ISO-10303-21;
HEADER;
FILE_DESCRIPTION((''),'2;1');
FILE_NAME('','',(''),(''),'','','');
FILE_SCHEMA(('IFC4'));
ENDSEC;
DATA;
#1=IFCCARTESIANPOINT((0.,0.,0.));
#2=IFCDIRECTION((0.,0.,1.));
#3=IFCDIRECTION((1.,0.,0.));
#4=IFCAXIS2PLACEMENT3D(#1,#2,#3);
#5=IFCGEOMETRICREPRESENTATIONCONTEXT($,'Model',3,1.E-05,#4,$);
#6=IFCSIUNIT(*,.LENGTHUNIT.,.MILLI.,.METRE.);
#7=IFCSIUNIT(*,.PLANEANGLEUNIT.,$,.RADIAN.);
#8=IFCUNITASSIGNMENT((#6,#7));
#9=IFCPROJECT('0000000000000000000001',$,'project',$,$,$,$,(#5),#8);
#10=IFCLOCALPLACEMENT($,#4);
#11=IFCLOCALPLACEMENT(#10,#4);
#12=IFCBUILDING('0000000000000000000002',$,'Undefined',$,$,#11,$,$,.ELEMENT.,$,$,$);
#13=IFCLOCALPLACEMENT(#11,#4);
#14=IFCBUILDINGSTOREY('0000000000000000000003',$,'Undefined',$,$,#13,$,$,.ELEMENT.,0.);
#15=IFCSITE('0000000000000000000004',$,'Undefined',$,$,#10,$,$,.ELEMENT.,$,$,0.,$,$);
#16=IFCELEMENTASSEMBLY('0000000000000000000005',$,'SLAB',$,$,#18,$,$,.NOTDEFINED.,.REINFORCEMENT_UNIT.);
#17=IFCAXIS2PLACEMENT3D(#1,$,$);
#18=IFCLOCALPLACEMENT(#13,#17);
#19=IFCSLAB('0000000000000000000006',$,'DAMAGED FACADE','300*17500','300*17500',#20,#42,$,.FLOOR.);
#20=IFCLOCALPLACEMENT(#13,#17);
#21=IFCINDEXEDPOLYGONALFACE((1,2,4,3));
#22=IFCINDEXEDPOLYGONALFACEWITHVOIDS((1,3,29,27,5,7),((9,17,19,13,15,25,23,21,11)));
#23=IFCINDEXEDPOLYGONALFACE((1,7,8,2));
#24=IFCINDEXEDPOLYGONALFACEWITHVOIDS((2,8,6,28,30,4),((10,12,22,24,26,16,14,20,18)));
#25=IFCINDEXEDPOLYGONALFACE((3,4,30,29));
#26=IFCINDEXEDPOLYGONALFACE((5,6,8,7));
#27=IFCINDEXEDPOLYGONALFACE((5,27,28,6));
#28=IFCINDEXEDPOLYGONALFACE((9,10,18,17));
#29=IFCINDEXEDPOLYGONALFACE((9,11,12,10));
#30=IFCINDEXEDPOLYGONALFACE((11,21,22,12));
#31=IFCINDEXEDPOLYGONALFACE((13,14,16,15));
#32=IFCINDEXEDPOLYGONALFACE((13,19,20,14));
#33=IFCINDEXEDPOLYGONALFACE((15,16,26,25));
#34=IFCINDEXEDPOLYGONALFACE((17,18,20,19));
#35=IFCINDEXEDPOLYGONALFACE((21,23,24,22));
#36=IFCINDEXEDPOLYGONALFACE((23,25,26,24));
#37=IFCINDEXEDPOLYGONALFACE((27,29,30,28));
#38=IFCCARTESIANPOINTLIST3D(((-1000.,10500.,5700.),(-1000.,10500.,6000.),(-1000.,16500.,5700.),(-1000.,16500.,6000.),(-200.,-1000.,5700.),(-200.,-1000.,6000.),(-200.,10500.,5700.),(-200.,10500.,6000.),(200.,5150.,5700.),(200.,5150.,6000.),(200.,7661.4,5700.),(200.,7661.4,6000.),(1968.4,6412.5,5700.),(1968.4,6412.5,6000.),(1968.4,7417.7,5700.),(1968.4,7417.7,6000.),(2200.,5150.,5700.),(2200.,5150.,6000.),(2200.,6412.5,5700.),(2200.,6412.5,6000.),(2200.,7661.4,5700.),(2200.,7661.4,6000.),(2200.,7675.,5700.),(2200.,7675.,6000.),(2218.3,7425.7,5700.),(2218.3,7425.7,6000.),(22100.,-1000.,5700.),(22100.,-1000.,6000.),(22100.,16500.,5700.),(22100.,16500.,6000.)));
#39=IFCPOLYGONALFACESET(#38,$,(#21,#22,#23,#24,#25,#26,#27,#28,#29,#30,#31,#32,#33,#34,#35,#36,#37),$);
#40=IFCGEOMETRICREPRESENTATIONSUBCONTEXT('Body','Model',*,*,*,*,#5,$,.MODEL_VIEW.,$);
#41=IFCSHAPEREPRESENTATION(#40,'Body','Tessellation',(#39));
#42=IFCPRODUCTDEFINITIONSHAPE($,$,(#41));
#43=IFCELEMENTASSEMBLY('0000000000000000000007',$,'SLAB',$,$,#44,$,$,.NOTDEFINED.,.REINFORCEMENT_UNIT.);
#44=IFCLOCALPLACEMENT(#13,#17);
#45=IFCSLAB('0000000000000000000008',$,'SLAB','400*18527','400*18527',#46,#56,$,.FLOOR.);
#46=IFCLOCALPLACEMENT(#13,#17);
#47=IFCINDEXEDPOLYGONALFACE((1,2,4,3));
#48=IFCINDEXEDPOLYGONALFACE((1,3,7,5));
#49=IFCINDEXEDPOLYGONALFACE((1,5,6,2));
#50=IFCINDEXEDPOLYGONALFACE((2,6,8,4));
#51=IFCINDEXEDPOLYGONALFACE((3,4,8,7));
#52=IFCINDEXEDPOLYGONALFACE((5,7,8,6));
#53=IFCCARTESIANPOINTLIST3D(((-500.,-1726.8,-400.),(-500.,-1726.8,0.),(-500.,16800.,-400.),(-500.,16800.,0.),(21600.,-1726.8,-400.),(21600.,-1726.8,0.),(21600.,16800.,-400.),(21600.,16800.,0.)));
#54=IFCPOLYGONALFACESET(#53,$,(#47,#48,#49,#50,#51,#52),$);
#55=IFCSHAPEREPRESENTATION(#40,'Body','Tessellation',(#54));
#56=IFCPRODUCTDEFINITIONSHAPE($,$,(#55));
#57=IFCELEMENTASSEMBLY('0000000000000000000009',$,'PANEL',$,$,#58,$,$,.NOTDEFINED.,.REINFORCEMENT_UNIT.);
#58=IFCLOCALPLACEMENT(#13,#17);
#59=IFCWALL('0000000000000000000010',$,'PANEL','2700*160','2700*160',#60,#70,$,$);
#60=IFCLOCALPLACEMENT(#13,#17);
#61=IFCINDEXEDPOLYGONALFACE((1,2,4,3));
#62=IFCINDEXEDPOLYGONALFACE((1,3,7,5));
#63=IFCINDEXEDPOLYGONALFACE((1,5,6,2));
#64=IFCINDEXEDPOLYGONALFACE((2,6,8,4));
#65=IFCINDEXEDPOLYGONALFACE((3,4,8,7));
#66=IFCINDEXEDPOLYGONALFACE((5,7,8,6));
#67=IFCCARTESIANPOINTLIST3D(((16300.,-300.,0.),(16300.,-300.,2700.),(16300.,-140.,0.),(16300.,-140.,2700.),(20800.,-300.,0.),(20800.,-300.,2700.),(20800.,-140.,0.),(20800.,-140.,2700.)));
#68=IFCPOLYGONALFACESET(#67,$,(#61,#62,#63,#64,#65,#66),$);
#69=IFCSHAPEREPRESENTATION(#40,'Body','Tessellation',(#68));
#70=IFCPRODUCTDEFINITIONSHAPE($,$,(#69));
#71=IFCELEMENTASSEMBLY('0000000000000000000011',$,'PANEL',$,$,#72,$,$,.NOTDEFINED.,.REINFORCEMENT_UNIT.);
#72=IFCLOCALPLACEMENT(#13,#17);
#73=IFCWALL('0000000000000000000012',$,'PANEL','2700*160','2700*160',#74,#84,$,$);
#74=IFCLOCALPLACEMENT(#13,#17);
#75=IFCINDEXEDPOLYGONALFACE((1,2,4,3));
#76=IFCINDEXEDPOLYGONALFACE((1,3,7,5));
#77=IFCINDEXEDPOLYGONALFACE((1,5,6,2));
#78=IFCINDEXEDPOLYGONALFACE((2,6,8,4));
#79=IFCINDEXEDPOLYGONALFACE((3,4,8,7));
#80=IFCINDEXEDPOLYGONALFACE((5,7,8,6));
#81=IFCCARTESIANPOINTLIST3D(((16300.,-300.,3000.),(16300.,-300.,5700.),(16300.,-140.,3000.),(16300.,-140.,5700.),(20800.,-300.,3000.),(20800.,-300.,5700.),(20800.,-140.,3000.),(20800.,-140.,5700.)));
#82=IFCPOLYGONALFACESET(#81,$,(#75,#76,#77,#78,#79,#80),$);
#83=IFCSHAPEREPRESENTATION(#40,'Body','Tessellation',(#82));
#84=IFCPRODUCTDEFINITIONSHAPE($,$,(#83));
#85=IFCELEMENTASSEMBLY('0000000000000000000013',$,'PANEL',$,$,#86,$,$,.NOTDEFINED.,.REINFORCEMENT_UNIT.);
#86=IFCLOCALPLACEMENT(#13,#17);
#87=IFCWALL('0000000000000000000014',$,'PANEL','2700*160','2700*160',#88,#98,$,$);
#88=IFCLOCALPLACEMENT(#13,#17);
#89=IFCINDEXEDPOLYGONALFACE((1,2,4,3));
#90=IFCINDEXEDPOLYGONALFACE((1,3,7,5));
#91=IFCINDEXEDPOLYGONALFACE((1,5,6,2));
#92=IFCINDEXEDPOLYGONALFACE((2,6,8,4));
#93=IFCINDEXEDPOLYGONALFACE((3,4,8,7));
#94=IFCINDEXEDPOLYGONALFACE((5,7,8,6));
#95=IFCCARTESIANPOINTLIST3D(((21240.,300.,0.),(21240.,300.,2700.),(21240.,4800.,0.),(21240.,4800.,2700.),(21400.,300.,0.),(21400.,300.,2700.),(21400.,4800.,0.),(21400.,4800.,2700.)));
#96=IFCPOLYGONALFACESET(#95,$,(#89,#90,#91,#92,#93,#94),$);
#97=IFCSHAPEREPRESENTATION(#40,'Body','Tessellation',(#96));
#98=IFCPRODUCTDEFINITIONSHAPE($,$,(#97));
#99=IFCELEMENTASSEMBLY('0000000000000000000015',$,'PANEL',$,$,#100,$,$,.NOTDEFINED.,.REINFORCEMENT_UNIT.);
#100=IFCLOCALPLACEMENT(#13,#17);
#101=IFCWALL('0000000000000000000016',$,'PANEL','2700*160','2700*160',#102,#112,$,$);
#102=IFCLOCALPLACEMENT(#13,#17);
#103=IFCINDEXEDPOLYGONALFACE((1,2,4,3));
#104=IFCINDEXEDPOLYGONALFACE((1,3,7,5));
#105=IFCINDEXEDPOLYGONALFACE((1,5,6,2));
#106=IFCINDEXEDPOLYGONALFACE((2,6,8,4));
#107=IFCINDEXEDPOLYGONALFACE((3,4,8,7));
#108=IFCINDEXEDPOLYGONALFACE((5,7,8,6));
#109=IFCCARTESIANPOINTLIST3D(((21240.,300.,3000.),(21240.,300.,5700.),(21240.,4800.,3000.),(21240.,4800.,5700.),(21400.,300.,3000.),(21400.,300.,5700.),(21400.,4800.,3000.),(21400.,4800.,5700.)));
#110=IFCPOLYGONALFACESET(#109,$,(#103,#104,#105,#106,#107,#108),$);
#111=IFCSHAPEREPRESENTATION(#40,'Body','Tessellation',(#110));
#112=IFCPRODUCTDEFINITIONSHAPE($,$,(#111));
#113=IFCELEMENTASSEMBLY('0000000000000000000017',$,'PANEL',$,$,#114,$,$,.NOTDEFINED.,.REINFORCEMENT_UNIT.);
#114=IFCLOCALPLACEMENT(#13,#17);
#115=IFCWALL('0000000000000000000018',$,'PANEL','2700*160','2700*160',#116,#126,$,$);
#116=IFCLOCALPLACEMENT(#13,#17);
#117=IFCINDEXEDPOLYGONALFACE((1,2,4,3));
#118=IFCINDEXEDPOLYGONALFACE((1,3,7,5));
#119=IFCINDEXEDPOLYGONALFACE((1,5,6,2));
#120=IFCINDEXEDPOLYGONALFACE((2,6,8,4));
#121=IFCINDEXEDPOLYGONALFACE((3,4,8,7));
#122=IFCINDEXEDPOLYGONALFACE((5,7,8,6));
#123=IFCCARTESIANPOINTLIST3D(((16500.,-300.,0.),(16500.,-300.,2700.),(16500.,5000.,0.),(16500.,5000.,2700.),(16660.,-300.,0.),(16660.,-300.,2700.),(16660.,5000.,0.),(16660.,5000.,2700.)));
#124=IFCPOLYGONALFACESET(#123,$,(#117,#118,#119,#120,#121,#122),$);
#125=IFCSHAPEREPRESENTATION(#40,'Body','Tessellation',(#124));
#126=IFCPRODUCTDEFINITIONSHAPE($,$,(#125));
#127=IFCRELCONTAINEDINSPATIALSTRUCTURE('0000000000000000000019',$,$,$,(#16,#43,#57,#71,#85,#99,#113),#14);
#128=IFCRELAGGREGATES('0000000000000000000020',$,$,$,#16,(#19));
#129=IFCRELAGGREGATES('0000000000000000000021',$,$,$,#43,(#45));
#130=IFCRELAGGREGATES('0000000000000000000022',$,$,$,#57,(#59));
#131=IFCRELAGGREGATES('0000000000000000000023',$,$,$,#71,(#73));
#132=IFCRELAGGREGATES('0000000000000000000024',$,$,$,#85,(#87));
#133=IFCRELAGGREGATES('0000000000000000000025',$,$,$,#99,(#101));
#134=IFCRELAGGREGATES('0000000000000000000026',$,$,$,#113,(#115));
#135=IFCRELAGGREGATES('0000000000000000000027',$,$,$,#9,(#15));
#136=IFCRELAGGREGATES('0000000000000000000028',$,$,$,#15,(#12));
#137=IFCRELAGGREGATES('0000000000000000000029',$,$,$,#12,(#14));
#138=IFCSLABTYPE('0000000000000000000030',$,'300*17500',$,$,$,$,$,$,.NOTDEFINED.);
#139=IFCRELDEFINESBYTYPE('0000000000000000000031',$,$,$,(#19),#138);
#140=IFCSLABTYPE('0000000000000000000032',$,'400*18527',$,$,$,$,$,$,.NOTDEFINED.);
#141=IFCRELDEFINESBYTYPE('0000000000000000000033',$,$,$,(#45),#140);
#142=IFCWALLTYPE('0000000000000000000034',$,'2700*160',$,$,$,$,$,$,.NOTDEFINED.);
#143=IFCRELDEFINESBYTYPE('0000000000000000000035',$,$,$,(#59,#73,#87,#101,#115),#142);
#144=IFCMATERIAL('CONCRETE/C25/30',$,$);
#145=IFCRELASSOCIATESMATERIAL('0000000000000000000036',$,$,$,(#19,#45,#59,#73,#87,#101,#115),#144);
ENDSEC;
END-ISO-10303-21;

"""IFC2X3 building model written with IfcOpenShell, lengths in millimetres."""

from ifc_helpers import new_model, si_unit, frame, frame_2d, origin_with_axes, place, context, subcontext, project, spatial, polyline, rectangle, outline, extrude, boolean, material, type_object, element, aggregate, save


model = new_model("IFC2X3")

# Units and contexts
model_context = context("Model", 3, precision=1e-05, world=origin_with_axes())
body_context = subcontext(model_context, "Body", "Model", "MODEL_VIEW")
ifc_project = project(units=[si_unit("LENGTHUNIT", "METRE", prefix="MILLI"), si_unit("PLANEANGLEUNIT", "RADIAN")], contexts=[model_context])

# Site, building, storey
site_placement = place(None, origin_with_axes())
site = spatial("IfcSite", under=ifc_project, at=site_placement, Name="Undefined", CompositionType="ELEMENT", RefElevation=0.0)
building_placement = place(site_placement, origin_with_axes())
building = spatial("IfcBuilding", under=site, at=building_placement, Name="Undefined", CompositionType="ELEMENT")
storey_placement = place(building_placement, origin_with_axes())
storey = spatial("IfcBuildingStorey", under=building, at=storey_placement, Name="Undefined", CompositionType="ELEMENT", Elevation=0.0)

# Shared definitions
ifc_material = material(Name="CONCRETE/C25/30")

# Element assemblies, slabs
assembly_1_placement = place(storey_placement, origin_with_axes())
assembly_1 = element("IfcElementAssembly", 1, at=assembly_1_placement, inside=storey, Name="SLAB", AssemblyPlace="NOTDEFINED", PredefinedType="REINFORCEMENT_UNIT")
slab_type_1 = type_object("IfcSlabType", Name="300*17500", PredefinedType="NOTDEFINED")
slab_1_placement = place(assembly_1_placement, frame((22100.0, -1000.0, 5850.0), z_axis=(0.0, 0.0, 1.0), x_axis=(0.0, 1.0, 0.0)))
slab_1 = element("IfcSlab", 2, at=slab_1_placement, type_object=slab_type_1, material=ifc_material, Name="DAMAGED FACADE", Description="300*17500", ObjectType="300*17500", PredefinedType="FLOOR", context=body_context, shape_type="CSG", body=[
    boolean("DIFFERENCE", extrude(outline(polyline([(0.0, 0.0), (17500.0, 0.0), (17500.0, 23100.0), (11500.0, 23100.0), (11500.0, 22300.0), (0.0, 22300.0), (0.0, 0.0), (0.0, 0.0)])), frame((0.0, 0.0, -150.0), z_axis=(0.0, 0.0, 1.0), x_axis=(1.0, 0.0, 0.0)), (0.0, 0.0, 1.0), 300.0), extrude(outline(polyline([(0.0, 0.0), (2000.0, 0.0), (2000.0, -13.6), (2018.3, 235.8), (1768.4, 243.7), (1768.4, 1248.9), (2000.0, 1248.9), (2000.0, 2511.4), (0.0, 2511.4), (0.0, 0.0), (0.0, 0.0)])), frame((8661.4, 21900.0, 152.5), z_axis=(0.0, 0.0, -1.0), x_axis=(0.0, -1.0, 0.0)), (0.0, 0.0, 1.0), 305.0)),
])
aggregate(assembly_1, [slab_1])
assembly_2_placement = place(storey_placement, origin_with_axes())
assembly_2 = element("IfcElementAssembly", 3, at=assembly_2_placement, inside=storey, Name="SLAB", AssemblyPlace="NOTDEFINED", PredefinedType="REINFORCEMENT_UNIT")
slab_type_2 = type_object("IfcSlabType", Name="400*18527", PredefinedType="NOTDEFINED")
slab_2_placement = place(assembly_2_placement, frame((21600.0, -1726.8, -200.0), z_axis=(0.0, 0.0, 1.0), x_axis=(0.0, 1.0, 0.0)))
slab_2 = element("IfcSlab", 4, at=slab_2_placement, type_object=slab_type_2, material=ifc_material, Name="SLAB", Description="400*18527", ObjectType="400*18527", PredefinedType="FLOOR", context=body_context, shape_type="SweptSolid", body=[
    extrude(outline(polyline([(0.0, 0.0), (18526.8, 0.0), (18526.8, 22100.0), (0.0, 22100.0), (0.0, 0.0), (0.0, 0.0)])), frame((0.0, 0.0, -200.0), z_axis=(0.0, 0.0, 1.0), x_axis=(1.0, 0.0, 0.0)), (0.0, 0.0, 1.0), 400.0),
])
aggregate(assembly_2, [slab_2])

# Element assemblies, walls
assembly_3_placement = place(storey_placement, origin_with_axes())
assembly_3 = element("IfcElementAssembly", 5, at=assembly_3_placement, inside=storey, Name="PANEL", AssemblyPlace="NOTDEFINED", PredefinedType="REINFORCEMENT_UNIT")
wall_type = type_object("IfcWallType", Name="2700*160", PredefinedType="NOTDEFINED")
wall_1_placement = place(assembly_3_placement, frame((16300.0, -220.0, 0.0), z_axis=(0.0, 0.0, 1.0), x_axis=(1.0, 0.0, 0.0)))
wall_1 = element("IfcWall", 6, at=wall_1_placement, type_object=wall_type, material=ifc_material, Name="PANEL", Description="2700*160", ObjectType="2700*160", context=body_context, shape_type="SweptSolid", body=[
    extrude(rectangle(XDim=4500.0, YDim=160.0, at=frame_2d((0.0, 2250.0), x_axis=(0.0, -1.0))), frame((0.0, 0.0, 0.0), z_axis=(0.0, 0.0, 1.0), x_axis=(0.0, -1.0, 0.0)), (0.0, 0.0, 1.0), 2700.0),
])
aggregate(assembly_3, [wall_1])
assembly_4_placement = place(storey_placement, origin_with_axes())
assembly_4 = element("IfcElementAssembly", 7, at=assembly_4_placement, inside=storey, Name="PANEL", AssemblyPlace="NOTDEFINED", PredefinedType="REINFORCEMENT_UNIT")
wall_2_placement = place(assembly_4_placement, frame((16300.0, -220.0, 3000.0), z_axis=(0.0, 0.0, 1.0), x_axis=(1.0, 0.0, 0.0)))
wall_2 = element("IfcWall", 8, at=wall_2_placement, type_object=wall_type, material=ifc_material, Name="PANEL", Description="2700*160", ObjectType="2700*160", context=body_context, shape_type="SweptSolid", body=[
    extrude(rectangle(XDim=4500.0, YDim=160.0, at=frame_2d((0.0, 2250.0), x_axis=(0.0, -1.0))), frame((0.0, 0.0, 0.0), z_axis=(0.0, 0.0, 1.0), x_axis=(0.0, -1.0, 0.0)), (0.0, 0.0, 1.0), 2700.0),
])
aggregate(assembly_4, [wall_2])
assembly_5_placement = place(storey_placement, origin_with_axes())
assembly_5 = element("IfcElementAssembly", 9, at=assembly_5_placement, inside=storey, Name="PANEL", AssemblyPlace="NOTDEFINED", PredefinedType="REINFORCEMENT_UNIT")
wall_3_placement = place(assembly_5_placement, frame((21320.0, 4800.0, 0.0), z_axis=(0.0, 0.0, 1.0), x_axis=(0.0, -1.0, 0.0)))
wall_3 = element("IfcWall", 10, at=wall_3_placement, type_object=wall_type, material=ifc_material, Name="PANEL", Description="2700*160", ObjectType="2700*160", context=body_context, shape_type="SweptSolid", body=[
    extrude(rectangle(XDim=4500.0, YDim=160.0, at=frame_2d((0.0, 2250.0), x_axis=(0.0, -1.0))), frame((0.0, 0.0, 0.0), z_axis=(0.0, 0.0, 1.0), x_axis=(0.0, -1.0, 0.0)), (0.0, 0.0, 1.0), 2700.0),
])
aggregate(assembly_5, [wall_3])
assembly_6_placement = place(storey_placement, origin_with_axes())
assembly_6 = element("IfcElementAssembly", 11, at=assembly_6_placement, inside=storey, Name="PANEL", AssemblyPlace="NOTDEFINED", PredefinedType="REINFORCEMENT_UNIT")
wall_4_placement = place(assembly_6_placement, frame((21320.0, 4800.0, 3000.0), z_axis=(0.0, 0.0, 1.0), x_axis=(0.0, -1.0, 0.0)))
wall_4 = element("IfcWall", 12, at=wall_4_placement, type_object=wall_type, material=ifc_material, Name="PANEL", Description="2700*160", ObjectType="2700*160", context=body_context, shape_type="SweptSolid", body=[
    extrude(rectangle(XDim=4500.0, YDim=160.0, at=frame_2d((0.0, 2250.0), x_axis=(0.0, -1.0))), frame((0.0, 0.0, 0.0), z_axis=(0.0, 0.0, 1.0), x_axis=(0.0, -1.0, 0.0)), (0.0, 0.0, 1.0), 2700.0),
])
aggregate(assembly_6, [wall_4])
assembly_7_placement = place(storey_placement, origin_with_axes())
assembly_7 = element("IfcElementAssembly", 13, at=assembly_7_placement, inside=storey, Name="PANEL", AssemblyPlace="NOTDEFINED", PredefinedType="REINFORCEMENT_UNIT")
wall_5_placement = place(assembly_7_placement, frame((16580.0, -300.0, 0.0), z_axis=(0.0, 0.0, 1.0), x_axis=(0.0, 1.0, 0.0)))
wall_5 = element("IfcWall", 14, at=wall_5_placement, type_object=wall_type, material=ifc_material, Name="PANEL", Description="2700*160", ObjectType="2700*160", context=body_context, shape_type="SweptSolid", body=[
    extrude(rectangle(XDim=5300.0, YDim=160.0, at=frame_2d((0.0, 2650.0), x_axis=(0.0, -1.0))), frame((0.0, 0.0, 0.0), z_axis=(0.0, 0.0, 1.0), x_axis=(0.0, -1.0, 0.0)), (0.0, 0.0, 1.0), 2700.0),
])
aggregate(assembly_7, [wall_5])

save(model, "model.ifc")
